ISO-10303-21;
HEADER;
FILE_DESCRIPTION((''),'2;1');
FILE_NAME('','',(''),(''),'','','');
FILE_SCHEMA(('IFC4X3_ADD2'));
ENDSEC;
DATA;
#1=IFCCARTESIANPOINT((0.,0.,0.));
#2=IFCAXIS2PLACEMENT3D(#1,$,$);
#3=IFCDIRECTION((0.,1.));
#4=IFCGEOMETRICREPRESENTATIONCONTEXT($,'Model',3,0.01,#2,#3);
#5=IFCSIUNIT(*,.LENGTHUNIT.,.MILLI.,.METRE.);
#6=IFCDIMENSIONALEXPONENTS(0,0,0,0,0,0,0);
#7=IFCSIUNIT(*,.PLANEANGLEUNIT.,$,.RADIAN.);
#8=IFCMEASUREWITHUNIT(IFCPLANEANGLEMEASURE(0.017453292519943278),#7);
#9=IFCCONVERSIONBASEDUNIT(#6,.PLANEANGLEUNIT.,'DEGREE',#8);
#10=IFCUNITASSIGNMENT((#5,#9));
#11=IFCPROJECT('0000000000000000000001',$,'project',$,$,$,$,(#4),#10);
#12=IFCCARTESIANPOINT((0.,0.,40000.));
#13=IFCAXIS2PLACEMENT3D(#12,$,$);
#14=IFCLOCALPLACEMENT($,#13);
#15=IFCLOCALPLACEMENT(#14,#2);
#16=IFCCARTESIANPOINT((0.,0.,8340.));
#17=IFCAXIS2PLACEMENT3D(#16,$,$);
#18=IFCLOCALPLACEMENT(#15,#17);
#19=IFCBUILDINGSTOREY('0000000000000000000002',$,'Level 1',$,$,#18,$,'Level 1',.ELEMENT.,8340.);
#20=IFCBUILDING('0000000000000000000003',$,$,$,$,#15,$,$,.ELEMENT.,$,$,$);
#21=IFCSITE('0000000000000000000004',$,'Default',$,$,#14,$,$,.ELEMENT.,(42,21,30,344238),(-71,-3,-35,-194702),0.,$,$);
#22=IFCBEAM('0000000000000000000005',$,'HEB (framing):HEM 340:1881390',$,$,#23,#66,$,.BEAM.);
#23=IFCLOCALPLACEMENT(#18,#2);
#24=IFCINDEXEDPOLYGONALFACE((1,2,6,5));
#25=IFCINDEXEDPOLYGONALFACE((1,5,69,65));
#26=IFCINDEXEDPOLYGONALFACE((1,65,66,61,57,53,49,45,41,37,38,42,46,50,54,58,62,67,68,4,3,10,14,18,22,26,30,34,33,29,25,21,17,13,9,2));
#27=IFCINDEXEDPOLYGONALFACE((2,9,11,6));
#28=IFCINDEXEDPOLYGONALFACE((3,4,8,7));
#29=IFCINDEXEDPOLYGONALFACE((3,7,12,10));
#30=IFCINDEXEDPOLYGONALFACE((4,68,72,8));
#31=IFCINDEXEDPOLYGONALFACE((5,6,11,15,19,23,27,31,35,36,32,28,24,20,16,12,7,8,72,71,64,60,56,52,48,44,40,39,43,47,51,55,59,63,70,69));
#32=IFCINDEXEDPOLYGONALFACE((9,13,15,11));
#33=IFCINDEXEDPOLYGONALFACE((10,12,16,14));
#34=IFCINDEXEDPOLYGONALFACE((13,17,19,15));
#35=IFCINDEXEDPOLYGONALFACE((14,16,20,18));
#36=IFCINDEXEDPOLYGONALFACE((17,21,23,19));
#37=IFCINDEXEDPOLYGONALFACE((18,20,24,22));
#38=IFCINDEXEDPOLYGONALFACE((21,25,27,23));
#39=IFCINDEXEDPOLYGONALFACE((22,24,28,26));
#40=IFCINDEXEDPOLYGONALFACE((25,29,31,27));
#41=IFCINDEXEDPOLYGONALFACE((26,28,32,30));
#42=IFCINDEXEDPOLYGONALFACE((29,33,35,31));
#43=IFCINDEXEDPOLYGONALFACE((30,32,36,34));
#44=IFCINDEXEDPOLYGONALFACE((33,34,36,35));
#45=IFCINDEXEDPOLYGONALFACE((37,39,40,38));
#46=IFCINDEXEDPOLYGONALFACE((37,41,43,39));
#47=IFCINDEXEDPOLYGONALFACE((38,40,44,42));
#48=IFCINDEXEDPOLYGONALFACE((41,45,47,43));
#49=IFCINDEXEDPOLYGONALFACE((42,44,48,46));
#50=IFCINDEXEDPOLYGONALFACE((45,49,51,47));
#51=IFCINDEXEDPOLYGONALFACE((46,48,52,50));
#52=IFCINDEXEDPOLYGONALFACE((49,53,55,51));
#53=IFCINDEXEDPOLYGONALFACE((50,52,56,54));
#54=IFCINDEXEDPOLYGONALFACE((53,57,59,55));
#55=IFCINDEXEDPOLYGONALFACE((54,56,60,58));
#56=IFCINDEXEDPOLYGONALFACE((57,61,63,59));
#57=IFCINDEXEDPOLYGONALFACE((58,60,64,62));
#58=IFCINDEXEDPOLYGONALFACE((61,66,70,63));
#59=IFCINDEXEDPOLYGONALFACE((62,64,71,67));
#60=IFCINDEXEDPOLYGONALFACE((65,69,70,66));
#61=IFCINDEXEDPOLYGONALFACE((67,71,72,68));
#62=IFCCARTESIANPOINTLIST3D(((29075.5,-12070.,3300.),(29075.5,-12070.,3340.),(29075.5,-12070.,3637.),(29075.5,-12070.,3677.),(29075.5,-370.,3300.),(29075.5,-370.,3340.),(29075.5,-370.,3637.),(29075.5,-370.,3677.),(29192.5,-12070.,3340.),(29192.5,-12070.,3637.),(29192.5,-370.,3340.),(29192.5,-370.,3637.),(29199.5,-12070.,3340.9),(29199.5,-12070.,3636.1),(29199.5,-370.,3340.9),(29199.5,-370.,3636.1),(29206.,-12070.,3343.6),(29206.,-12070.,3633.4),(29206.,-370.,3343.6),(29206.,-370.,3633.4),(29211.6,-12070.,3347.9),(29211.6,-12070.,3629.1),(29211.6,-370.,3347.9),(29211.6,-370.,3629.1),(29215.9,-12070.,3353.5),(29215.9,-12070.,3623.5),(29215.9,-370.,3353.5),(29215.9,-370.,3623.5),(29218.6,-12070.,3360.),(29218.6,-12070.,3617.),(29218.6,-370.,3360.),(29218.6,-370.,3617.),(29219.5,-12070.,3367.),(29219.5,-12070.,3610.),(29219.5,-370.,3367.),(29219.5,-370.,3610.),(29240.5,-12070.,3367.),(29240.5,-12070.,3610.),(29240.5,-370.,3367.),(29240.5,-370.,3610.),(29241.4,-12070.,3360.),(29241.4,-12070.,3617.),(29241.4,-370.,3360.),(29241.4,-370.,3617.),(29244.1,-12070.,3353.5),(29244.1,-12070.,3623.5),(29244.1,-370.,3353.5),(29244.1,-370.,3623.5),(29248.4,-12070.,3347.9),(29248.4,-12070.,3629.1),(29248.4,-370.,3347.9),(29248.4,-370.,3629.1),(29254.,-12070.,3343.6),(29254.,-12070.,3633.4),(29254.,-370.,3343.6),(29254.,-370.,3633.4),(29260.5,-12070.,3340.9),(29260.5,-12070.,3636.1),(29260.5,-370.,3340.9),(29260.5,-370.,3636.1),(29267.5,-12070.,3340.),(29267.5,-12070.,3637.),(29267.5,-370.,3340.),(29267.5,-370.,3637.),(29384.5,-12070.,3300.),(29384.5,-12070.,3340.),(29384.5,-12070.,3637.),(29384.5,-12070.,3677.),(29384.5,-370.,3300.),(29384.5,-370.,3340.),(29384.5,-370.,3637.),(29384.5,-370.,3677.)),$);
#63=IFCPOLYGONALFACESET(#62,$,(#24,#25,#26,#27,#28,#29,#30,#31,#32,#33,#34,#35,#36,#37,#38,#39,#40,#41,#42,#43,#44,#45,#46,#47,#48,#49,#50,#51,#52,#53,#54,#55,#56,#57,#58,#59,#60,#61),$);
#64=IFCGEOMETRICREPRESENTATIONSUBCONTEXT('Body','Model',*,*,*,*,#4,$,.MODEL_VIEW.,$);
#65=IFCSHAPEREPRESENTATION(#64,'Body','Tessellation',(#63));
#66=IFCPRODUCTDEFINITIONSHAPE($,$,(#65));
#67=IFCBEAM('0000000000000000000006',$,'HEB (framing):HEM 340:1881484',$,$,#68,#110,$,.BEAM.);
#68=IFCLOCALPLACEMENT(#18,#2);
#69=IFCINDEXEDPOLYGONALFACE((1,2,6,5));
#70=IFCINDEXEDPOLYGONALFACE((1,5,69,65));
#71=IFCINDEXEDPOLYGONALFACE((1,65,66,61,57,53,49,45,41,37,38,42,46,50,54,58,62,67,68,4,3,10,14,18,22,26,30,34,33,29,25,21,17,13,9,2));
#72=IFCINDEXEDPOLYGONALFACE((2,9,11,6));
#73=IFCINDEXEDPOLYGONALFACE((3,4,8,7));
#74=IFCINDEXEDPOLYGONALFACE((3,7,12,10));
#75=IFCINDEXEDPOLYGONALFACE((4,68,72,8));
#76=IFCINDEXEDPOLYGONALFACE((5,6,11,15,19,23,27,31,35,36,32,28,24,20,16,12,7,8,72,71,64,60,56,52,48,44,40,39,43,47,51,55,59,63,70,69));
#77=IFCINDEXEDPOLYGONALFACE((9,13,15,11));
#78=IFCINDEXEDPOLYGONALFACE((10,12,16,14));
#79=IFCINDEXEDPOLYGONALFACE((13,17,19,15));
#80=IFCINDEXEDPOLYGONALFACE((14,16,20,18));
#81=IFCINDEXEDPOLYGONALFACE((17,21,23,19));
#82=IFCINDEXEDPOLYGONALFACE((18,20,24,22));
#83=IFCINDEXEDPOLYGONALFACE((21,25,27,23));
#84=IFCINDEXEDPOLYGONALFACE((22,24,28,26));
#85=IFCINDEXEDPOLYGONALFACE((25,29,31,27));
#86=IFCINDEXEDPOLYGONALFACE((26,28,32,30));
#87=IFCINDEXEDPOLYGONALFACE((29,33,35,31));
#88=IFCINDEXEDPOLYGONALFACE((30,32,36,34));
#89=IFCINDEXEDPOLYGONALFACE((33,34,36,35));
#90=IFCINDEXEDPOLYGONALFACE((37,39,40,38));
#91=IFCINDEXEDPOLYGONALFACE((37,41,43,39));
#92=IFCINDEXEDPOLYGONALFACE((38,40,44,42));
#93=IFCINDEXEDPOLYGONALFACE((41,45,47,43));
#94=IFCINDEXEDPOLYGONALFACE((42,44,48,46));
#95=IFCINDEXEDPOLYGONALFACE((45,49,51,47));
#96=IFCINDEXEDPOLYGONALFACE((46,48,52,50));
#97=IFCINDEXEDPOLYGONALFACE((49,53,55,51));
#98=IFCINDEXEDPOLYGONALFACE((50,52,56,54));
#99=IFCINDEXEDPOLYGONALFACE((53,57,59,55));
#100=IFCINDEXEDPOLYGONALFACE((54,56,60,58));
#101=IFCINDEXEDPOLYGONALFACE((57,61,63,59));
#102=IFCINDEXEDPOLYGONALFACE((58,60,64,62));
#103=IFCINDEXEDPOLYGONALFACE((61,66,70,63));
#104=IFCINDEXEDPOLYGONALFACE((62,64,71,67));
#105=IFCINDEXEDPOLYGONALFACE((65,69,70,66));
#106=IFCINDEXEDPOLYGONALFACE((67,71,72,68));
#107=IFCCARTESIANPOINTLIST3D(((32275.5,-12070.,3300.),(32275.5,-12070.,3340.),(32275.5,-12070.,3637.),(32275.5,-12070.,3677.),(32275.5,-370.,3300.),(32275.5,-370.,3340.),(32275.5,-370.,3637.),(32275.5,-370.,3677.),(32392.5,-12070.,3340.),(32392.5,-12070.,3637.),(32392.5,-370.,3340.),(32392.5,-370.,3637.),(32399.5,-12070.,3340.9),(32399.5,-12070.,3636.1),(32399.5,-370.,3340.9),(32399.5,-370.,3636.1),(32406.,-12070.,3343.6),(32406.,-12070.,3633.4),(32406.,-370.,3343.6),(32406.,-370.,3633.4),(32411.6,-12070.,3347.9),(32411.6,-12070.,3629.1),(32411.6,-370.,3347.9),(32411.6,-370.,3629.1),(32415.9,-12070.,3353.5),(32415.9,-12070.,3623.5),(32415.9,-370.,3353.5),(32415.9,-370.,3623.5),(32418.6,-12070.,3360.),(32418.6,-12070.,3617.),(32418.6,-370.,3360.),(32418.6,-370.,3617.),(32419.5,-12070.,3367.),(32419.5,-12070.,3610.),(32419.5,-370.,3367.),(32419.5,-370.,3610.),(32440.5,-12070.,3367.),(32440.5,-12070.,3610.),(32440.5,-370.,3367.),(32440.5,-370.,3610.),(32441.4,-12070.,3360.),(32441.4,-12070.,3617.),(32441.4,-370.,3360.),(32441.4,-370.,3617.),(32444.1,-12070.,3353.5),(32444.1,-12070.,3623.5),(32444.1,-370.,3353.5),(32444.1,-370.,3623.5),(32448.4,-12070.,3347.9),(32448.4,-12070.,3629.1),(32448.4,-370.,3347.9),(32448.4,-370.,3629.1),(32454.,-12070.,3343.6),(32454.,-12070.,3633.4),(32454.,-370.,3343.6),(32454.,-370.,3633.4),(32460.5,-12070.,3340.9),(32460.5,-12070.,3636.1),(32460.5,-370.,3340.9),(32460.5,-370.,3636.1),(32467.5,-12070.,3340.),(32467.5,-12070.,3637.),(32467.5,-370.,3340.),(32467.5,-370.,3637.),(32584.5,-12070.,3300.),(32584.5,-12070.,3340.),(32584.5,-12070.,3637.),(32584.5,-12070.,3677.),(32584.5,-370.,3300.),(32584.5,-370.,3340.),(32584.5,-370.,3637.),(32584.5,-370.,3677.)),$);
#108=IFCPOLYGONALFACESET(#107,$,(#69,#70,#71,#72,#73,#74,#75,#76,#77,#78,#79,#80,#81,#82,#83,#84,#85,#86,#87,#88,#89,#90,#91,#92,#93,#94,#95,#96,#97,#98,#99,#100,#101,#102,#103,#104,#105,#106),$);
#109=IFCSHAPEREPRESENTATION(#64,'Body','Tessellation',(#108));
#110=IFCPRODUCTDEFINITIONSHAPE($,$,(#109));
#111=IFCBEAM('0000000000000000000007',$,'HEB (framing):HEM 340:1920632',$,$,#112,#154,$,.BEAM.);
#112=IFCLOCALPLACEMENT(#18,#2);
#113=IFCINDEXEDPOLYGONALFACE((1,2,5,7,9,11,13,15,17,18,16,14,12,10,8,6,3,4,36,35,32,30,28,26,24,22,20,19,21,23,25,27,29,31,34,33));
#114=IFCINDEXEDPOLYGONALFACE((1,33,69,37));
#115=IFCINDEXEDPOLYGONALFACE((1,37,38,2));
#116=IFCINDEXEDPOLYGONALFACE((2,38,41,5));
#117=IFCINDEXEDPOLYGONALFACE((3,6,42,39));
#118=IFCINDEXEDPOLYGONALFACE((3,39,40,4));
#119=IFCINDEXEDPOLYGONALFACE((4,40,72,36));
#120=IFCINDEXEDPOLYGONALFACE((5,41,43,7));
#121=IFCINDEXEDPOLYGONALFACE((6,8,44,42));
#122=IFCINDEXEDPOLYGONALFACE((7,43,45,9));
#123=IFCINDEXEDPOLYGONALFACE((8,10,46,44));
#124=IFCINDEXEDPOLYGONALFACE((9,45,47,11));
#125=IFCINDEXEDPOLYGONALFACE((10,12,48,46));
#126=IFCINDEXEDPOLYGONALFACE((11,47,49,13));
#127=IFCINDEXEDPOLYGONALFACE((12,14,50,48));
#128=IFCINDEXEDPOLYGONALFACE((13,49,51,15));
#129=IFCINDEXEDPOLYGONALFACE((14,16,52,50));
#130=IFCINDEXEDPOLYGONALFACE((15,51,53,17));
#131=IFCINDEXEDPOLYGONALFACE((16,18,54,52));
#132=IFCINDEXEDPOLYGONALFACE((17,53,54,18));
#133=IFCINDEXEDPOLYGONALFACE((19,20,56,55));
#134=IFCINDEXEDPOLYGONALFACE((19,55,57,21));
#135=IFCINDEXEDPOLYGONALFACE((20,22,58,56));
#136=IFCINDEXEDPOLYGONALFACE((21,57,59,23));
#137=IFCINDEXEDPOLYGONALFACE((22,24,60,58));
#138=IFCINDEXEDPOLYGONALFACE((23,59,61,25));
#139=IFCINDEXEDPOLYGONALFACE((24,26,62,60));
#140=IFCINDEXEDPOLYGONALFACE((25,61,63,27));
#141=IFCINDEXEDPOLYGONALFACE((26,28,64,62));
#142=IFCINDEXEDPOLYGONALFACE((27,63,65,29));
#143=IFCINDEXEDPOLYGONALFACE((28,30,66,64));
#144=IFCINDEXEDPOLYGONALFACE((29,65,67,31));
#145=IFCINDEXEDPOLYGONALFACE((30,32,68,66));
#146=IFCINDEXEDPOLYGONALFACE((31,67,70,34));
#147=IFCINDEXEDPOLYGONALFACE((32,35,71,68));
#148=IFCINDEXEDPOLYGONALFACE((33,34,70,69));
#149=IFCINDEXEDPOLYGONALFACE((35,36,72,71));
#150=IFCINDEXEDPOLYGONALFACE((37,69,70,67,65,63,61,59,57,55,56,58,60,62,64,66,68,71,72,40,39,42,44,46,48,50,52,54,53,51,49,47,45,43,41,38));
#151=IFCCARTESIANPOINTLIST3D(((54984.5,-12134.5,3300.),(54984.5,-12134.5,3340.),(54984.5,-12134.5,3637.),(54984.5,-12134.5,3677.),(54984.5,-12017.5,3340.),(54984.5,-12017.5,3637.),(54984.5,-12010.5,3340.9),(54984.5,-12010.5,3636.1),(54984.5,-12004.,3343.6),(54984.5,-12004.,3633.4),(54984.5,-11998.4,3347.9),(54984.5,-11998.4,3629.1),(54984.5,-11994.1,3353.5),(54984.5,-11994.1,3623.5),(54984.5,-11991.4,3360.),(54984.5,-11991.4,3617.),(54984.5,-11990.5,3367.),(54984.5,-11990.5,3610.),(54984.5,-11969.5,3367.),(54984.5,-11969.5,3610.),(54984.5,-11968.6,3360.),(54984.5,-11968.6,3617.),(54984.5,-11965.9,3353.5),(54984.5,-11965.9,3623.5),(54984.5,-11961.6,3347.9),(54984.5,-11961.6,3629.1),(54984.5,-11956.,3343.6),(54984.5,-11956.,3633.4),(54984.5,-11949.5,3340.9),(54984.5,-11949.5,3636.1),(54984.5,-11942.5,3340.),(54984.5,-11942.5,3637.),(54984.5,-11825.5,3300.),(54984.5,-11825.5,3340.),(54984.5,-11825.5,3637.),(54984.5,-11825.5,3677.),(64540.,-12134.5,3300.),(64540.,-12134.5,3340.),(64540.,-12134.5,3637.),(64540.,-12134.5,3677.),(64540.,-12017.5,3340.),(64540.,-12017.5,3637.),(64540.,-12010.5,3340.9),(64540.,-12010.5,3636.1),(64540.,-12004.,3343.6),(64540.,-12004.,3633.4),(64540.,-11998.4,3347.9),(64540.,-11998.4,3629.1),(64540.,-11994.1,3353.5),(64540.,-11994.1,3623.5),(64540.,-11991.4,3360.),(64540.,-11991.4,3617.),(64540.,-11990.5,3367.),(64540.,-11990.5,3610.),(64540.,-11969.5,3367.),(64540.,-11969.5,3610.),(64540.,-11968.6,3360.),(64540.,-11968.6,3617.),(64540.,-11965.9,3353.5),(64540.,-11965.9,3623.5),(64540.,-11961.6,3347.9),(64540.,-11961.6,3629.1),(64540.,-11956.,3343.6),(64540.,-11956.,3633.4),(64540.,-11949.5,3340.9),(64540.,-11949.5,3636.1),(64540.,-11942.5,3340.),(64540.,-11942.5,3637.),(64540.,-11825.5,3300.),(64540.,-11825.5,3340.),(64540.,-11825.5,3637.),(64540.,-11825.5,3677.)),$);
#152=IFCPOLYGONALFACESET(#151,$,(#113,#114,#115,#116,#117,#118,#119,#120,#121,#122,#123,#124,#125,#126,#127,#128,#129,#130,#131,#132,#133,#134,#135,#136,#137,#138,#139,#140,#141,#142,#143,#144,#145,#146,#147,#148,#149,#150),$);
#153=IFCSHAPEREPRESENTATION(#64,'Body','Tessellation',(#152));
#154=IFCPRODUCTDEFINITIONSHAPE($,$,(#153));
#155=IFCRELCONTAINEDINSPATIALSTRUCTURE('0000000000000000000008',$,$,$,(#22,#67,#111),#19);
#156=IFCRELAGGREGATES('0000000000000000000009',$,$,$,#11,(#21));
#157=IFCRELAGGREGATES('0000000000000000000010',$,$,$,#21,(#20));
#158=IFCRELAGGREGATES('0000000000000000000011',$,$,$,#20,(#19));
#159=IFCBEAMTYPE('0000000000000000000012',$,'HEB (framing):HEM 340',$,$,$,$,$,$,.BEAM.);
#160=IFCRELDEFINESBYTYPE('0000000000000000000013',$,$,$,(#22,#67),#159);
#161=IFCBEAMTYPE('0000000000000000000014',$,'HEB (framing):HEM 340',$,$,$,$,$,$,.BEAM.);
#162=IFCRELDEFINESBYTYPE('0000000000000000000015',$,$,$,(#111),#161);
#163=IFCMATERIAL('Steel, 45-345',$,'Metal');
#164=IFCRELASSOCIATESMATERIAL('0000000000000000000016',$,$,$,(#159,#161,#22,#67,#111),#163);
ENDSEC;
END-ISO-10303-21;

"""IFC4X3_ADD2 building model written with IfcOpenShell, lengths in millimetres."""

from ifc_helpers import new_model, entity, si_unit, converted_unit, direction, frame, frame_2d, origin, place, context, subcontext, project, spatial, polyline, circle_curve, parameter, trimmed, segment, composite_curve, outline, extrude, source, transform, mapped, material, material_profile, profile_set, profile_usage, type_object, type_shapes, element, save


model = new_model("IFC4X3_ADD2")

# Units and contexts
model_context = context("Model", 3, precision=0.01, world=origin(), true_north=direction((0.0, 1.0)))
body_context = subcontext(model_context, "Body", "Model", "MODEL_VIEW")
ifc_project = project(units=[si_unit("LENGTHUNIT", "METRE", prefix="MILLI"), converted_unit("PLANEANGLEUNIT", "DEGREE", entity("IfcPlaneAngleMeasure", 0.017453292519943278), si_unit("PLANEANGLEUNIT", "RADIAN"), dimensions=[0, 0, 0, 0, 0, 0, 0])], contexts=[model_context])

# Site, building, storey
site_placement = place(None, frame((0.0, 0.0, 40000.0)))
site = spatial("IfcSite", under=ifc_project, at=site_placement, Name="Default", CompositionType="ELEMENT", RefLatitude=(42, 21, 30, 344238), RefLongitude=(-71, -3, -35, -194702), RefElevation=0.0)
building_placement = place(site_placement, origin())
building = spatial("IfcBuilding", under=site, at=building_placement, CompositionType="ELEMENT")
storey_placement = place(building_placement, frame((0.0, 0.0, 8340.0)))
storey = spatial("IfcBuildingStorey", under=building, at=storey_placement, Name="Level 1", LongName="Level 1", CompositionType="ELEMENT", Elevation=8340.0)

# Shared definitions
ifc_material = material(Name="Steel, 45-345", Category="Metal")

# Beams
ifc_material_profile_1 = material_profile(ifc_material, outline(composite_curve([segment(polyline([(-154.5, -148.5), (-154.5, -188.5)]), True, "CONTINUOUS"), segment(polyline([(-154.5, -188.5), (154.5, -188.5)]), True, "CONTINUOUS"), segment(polyline([(154.5, -188.5), (154.5, -148.5)]), True, "CONTINUOUS"), segment(polyline([(154.5, -148.5), (37.5, -148.5)]), True, "CONTINUOUS"), segment(trimmed(circle_curve(frame_2d((37.5, -121.5), x_axis=(1.0, 0.0)), 27.0), [parameter(180.0)], [parameter(270.0)], True, "PARAMETER"), False, "CONTINUOUS"), segment(polyline([(10.5, -121.5), (10.5, 121.5)]), True, "CONTINUOUS"), segment(trimmed(circle_curve(frame_2d((37.5, 121.5), x_axis=(1.0, 0.0)), 27.0), [parameter(90.0)], [parameter(180.0)], True, "PARAMETER"), False, "CONTINUOUS"), segment(polyline([(37.5, 148.5), (154.5, 148.5)]), True, "CONTINUOUS"), segment(polyline([(154.5, 148.5), (154.5, 188.5)]), True, "CONTINUOUS"), segment(polyline([(154.5, 188.5), (-154.5, 188.5)]), True, "CONTINUOUS"), segment(polyline([(-154.5, 188.5), (-154.5, 148.5)]), True, "CONTINUOUS"), segment(polyline([(-154.5, 148.5), (-37.5, 148.5)]), True, "CONTINUOUS"), segment(trimmed(circle_curve(frame_2d((-37.5, 121.5), x_axis=(1.0, 0.0)), 27.0), [parameter(360.0)], [parameter(90.0)], True, "PARAMETER"), False, "CONTINUOUS"), segment(polyline([(-10.5, 121.5), (-10.5, -121.5)]), True, "CONTINUOUS"), segment(trimmed(circle_curve(frame_2d((-37.5, -121.5), x_axis=(1.0, 0.0)), 27.0), [parameter(270.0)], [parameter(0.0)], True, "PARAMETER"), False, "CONTINUOUS"), segment(polyline([(-37.5, -148.5), (-154.5, -148.5)]), True, "CONTINUOUS")], self_intersect=False)), Name="HEM 340")
ifc_profile_set_1 = profile_set([ifc_material_profile_1], Name="HEM 340")
ifc_profile_usage_1 = profile_usage(ifc_profile_set_1, cardinal=8)
beam_type_1 = type_object("IfcBeamType", Name="HEB (framing):HEM 340", PredefinedType="BEAM", material=ifc_profile_set_1)
shared_shape_1 = source(origin(), body_context, "Body", "SweptSolid", [
    extrude(outline(composite_curve([segment(polyline([(-154.5, -148.5), (-154.5, -188.5)]), True, "CONTINUOUS"), segment(polyline([(-154.5, -188.5), (154.5, -188.5)]), True, "CONTINUOUS"), segment(polyline([(154.5, -188.5), (154.5, -148.5)]), True, "CONTINUOUS"), segment(polyline([(154.5, -148.5), (37.5, -148.5)]), True, "CONTINUOUS"), segment(trimmed(circle_curve(frame_2d((37.5, -121.5), x_axis=(1.0, 0.0)), 27.0), [parameter(180.0)], [parameter(270.0)], True, "PARAMETER"), False, "CONTINUOUS"), segment(polyline([(10.5, -121.5), (10.5, 121.5)]), True, "CONTINUOUS"), segment(trimmed(circle_curve(frame_2d((37.5, 121.5), x_axis=(1.0, 0.0)), 27.0), [parameter(90.0)], [parameter(180.0)], True, "PARAMETER"), False, "CONTINUOUS"), segment(polyline([(37.5, 148.5), (154.5, 148.5)]), True, "CONTINUOUS"), segment(polyline([(154.5, 148.5), (154.5, 188.5)]), True, "CONTINUOUS"), segment(polyline([(154.5, 188.5), (-154.5, 188.5)]), True, "CONTINUOUS"), segment(polyline([(-154.5, 188.5), (-154.5, 148.5)]), True, "CONTINUOUS"), segment(polyline([(-154.5, 148.5), (-37.5, 148.5)]), True, "CONTINUOUS"), segment(trimmed(circle_curve(frame_2d((-37.5, 121.5), x_axis=(1.0, 0.0)), 27.0), [parameter(360.0)], [parameter(90.0)], True, "PARAMETER"), False, "CONTINUOUS"), segment(polyline([(-10.5, 121.5), (-10.5, -121.5)]), True, "CONTINUOUS"), segment(trimmed(circle_curve(frame_2d((-37.5, -121.5), x_axis=(1.0, 0.0)), 27.0), [parameter(270.0)], [parameter(0.0)], True, "PARAMETER"), False, "CONTINUOUS"), segment(polyline([(-37.5, -148.5), (-154.5, -148.5)]), True, "CONTINUOUS")], self_intersect=False)), frame((-5850.0, 0.0, 0.0), z_axis=(-1.0, 0.0, 0.0), x_axis=(0.0, -1.0, 0.0)), (0.0, 0.0, -1.0), 11700.0),
])
type_shapes(beam_type_1, [shared_shape_1])
for number, where, z_axis, x_axis, name in (
    (1, (29230.0, -6220.0, 3488.5), (0.0, 0.0, 1.0), (0.0, -1.0, 0.0), "HEB (framing):HEM 340:1881390"),
    (2, (32430.0, -6220.0, 3488.5), (0.0, 0.0, 1.0), (0.0, -1.0, 0.0), "HEB (framing):HEM 340:1881484"),
):
    element("IfcBeam", number, at=place(storey_placement, frame(where, z_axis=z_axis, x_axis=x_axis)), inside=storey, type_object=beam_type_1, material=ifc_profile_usage_1, Name=name, PredefinedType="BEAM", context=body_context, shape_type="MappedRepresentation", body=[
        mapped(shared_shape_1, transform((0.0, 0.0, 0.0), scale=1.0)),
    ])
beam_type_2 = type_object("IfcBeamType", Name="HEB (framing):HEM 340", PredefinedType="BEAM", material=ifc_profile_set_1)
shared_shape_2 = source(origin(), body_context, "Body", "SweptSolid", [
    extrude(outline(composite_curve([segment(polyline([(-154.5, -148.5), (-154.5, -188.5)]), True, "CONTINUOUS"), segment(polyline([(-154.5, -188.5), (154.5, -188.5)]), True, "CONTINUOUS"), segment(polyline([(154.5, -188.5), (154.5, -148.5)]), True, "CONTINUOUS"), segment(polyline([(154.5, -148.5), (37.5, -148.5)]), True, "CONTINUOUS"), segment(trimmed(circle_curve(frame_2d((37.5, -121.5), x_axis=(1.0, 0.0)), 27.0), [parameter(180.0)], [parameter(270.0)], True, "PARAMETER"), False, "CONTINUOUS"), segment(polyline([(10.5, -121.5), (10.5, 121.5)]), True, "CONTINUOUS"), segment(trimmed(circle_curve(frame_2d((37.5, 121.5), x_axis=(1.0, 0.0)), 27.0), [parameter(90.0)], [parameter(180.0)], True, "PARAMETER"), False, "CONTINUOUS"), segment(polyline([(37.5, 148.5), (154.5, 148.5)]), True, "CONTINUOUS"), segment(polyline([(154.5, 148.5), (154.5, 188.5)]), True, "CONTINUOUS"), segment(polyline([(154.5, 188.5), (-154.5, 188.5)]), True, "CONTINUOUS"), segment(polyline([(-154.5, 188.5), (-154.5, 148.5)]), True, "CONTINUOUS"), segment(polyline([(-154.5, 148.5), (-37.5, 148.5)]), True, "CONTINUOUS"), segment(trimmed(circle_curve(frame_2d((-37.5, 121.5), x_axis=(1.0, 0.0)), 27.0), [parameter(360.0)], [parameter(90.0)], True, "PARAMETER"), False, "CONTINUOUS"), segment(polyline([(-10.5, 121.5), (-10.5, -121.5)]), True, "CONTINUOUS"), segment(trimmed(circle_curve(frame_2d((-37.5, -121.5), x_axis=(1.0, 0.0)), 27.0), [parameter(270.0)], [parameter(0.0)], True, "PARAMETER"), False, "CONTINUOUS"), segment(polyline([(-37.5, -148.5), (-154.5, -148.5)]), True, "CONTINUOUS")], self_intersect=False)), frame((-4703.0, 0.0, 0.0), z_axis=(-1.0, 0.0, 0.0), x_axis=(0.0, -1.0, 0.0)), (0.0, 0.0, -1.0), 9555.5),
])
type_shapes(beam_type_2, [shared_shape_2])
beam_1_placement = place(storey_placement, frame((59687.5, -11980.0, 3488.5)))
element("IfcBeam", 3, at=beam_1_placement, inside=storey, type_object=beam_type_2, material=ifc_profile_usage_1, Name="HEB (framing):HEM 340:1920632", PredefinedType="BEAM", context=body_context, shape_type="MappedRepresentation", body=[
    mapped(shared_shape_2, transform((0.0, 0.0, 0.0), scale=1.0)),
])

save(model, "model.ifc")
